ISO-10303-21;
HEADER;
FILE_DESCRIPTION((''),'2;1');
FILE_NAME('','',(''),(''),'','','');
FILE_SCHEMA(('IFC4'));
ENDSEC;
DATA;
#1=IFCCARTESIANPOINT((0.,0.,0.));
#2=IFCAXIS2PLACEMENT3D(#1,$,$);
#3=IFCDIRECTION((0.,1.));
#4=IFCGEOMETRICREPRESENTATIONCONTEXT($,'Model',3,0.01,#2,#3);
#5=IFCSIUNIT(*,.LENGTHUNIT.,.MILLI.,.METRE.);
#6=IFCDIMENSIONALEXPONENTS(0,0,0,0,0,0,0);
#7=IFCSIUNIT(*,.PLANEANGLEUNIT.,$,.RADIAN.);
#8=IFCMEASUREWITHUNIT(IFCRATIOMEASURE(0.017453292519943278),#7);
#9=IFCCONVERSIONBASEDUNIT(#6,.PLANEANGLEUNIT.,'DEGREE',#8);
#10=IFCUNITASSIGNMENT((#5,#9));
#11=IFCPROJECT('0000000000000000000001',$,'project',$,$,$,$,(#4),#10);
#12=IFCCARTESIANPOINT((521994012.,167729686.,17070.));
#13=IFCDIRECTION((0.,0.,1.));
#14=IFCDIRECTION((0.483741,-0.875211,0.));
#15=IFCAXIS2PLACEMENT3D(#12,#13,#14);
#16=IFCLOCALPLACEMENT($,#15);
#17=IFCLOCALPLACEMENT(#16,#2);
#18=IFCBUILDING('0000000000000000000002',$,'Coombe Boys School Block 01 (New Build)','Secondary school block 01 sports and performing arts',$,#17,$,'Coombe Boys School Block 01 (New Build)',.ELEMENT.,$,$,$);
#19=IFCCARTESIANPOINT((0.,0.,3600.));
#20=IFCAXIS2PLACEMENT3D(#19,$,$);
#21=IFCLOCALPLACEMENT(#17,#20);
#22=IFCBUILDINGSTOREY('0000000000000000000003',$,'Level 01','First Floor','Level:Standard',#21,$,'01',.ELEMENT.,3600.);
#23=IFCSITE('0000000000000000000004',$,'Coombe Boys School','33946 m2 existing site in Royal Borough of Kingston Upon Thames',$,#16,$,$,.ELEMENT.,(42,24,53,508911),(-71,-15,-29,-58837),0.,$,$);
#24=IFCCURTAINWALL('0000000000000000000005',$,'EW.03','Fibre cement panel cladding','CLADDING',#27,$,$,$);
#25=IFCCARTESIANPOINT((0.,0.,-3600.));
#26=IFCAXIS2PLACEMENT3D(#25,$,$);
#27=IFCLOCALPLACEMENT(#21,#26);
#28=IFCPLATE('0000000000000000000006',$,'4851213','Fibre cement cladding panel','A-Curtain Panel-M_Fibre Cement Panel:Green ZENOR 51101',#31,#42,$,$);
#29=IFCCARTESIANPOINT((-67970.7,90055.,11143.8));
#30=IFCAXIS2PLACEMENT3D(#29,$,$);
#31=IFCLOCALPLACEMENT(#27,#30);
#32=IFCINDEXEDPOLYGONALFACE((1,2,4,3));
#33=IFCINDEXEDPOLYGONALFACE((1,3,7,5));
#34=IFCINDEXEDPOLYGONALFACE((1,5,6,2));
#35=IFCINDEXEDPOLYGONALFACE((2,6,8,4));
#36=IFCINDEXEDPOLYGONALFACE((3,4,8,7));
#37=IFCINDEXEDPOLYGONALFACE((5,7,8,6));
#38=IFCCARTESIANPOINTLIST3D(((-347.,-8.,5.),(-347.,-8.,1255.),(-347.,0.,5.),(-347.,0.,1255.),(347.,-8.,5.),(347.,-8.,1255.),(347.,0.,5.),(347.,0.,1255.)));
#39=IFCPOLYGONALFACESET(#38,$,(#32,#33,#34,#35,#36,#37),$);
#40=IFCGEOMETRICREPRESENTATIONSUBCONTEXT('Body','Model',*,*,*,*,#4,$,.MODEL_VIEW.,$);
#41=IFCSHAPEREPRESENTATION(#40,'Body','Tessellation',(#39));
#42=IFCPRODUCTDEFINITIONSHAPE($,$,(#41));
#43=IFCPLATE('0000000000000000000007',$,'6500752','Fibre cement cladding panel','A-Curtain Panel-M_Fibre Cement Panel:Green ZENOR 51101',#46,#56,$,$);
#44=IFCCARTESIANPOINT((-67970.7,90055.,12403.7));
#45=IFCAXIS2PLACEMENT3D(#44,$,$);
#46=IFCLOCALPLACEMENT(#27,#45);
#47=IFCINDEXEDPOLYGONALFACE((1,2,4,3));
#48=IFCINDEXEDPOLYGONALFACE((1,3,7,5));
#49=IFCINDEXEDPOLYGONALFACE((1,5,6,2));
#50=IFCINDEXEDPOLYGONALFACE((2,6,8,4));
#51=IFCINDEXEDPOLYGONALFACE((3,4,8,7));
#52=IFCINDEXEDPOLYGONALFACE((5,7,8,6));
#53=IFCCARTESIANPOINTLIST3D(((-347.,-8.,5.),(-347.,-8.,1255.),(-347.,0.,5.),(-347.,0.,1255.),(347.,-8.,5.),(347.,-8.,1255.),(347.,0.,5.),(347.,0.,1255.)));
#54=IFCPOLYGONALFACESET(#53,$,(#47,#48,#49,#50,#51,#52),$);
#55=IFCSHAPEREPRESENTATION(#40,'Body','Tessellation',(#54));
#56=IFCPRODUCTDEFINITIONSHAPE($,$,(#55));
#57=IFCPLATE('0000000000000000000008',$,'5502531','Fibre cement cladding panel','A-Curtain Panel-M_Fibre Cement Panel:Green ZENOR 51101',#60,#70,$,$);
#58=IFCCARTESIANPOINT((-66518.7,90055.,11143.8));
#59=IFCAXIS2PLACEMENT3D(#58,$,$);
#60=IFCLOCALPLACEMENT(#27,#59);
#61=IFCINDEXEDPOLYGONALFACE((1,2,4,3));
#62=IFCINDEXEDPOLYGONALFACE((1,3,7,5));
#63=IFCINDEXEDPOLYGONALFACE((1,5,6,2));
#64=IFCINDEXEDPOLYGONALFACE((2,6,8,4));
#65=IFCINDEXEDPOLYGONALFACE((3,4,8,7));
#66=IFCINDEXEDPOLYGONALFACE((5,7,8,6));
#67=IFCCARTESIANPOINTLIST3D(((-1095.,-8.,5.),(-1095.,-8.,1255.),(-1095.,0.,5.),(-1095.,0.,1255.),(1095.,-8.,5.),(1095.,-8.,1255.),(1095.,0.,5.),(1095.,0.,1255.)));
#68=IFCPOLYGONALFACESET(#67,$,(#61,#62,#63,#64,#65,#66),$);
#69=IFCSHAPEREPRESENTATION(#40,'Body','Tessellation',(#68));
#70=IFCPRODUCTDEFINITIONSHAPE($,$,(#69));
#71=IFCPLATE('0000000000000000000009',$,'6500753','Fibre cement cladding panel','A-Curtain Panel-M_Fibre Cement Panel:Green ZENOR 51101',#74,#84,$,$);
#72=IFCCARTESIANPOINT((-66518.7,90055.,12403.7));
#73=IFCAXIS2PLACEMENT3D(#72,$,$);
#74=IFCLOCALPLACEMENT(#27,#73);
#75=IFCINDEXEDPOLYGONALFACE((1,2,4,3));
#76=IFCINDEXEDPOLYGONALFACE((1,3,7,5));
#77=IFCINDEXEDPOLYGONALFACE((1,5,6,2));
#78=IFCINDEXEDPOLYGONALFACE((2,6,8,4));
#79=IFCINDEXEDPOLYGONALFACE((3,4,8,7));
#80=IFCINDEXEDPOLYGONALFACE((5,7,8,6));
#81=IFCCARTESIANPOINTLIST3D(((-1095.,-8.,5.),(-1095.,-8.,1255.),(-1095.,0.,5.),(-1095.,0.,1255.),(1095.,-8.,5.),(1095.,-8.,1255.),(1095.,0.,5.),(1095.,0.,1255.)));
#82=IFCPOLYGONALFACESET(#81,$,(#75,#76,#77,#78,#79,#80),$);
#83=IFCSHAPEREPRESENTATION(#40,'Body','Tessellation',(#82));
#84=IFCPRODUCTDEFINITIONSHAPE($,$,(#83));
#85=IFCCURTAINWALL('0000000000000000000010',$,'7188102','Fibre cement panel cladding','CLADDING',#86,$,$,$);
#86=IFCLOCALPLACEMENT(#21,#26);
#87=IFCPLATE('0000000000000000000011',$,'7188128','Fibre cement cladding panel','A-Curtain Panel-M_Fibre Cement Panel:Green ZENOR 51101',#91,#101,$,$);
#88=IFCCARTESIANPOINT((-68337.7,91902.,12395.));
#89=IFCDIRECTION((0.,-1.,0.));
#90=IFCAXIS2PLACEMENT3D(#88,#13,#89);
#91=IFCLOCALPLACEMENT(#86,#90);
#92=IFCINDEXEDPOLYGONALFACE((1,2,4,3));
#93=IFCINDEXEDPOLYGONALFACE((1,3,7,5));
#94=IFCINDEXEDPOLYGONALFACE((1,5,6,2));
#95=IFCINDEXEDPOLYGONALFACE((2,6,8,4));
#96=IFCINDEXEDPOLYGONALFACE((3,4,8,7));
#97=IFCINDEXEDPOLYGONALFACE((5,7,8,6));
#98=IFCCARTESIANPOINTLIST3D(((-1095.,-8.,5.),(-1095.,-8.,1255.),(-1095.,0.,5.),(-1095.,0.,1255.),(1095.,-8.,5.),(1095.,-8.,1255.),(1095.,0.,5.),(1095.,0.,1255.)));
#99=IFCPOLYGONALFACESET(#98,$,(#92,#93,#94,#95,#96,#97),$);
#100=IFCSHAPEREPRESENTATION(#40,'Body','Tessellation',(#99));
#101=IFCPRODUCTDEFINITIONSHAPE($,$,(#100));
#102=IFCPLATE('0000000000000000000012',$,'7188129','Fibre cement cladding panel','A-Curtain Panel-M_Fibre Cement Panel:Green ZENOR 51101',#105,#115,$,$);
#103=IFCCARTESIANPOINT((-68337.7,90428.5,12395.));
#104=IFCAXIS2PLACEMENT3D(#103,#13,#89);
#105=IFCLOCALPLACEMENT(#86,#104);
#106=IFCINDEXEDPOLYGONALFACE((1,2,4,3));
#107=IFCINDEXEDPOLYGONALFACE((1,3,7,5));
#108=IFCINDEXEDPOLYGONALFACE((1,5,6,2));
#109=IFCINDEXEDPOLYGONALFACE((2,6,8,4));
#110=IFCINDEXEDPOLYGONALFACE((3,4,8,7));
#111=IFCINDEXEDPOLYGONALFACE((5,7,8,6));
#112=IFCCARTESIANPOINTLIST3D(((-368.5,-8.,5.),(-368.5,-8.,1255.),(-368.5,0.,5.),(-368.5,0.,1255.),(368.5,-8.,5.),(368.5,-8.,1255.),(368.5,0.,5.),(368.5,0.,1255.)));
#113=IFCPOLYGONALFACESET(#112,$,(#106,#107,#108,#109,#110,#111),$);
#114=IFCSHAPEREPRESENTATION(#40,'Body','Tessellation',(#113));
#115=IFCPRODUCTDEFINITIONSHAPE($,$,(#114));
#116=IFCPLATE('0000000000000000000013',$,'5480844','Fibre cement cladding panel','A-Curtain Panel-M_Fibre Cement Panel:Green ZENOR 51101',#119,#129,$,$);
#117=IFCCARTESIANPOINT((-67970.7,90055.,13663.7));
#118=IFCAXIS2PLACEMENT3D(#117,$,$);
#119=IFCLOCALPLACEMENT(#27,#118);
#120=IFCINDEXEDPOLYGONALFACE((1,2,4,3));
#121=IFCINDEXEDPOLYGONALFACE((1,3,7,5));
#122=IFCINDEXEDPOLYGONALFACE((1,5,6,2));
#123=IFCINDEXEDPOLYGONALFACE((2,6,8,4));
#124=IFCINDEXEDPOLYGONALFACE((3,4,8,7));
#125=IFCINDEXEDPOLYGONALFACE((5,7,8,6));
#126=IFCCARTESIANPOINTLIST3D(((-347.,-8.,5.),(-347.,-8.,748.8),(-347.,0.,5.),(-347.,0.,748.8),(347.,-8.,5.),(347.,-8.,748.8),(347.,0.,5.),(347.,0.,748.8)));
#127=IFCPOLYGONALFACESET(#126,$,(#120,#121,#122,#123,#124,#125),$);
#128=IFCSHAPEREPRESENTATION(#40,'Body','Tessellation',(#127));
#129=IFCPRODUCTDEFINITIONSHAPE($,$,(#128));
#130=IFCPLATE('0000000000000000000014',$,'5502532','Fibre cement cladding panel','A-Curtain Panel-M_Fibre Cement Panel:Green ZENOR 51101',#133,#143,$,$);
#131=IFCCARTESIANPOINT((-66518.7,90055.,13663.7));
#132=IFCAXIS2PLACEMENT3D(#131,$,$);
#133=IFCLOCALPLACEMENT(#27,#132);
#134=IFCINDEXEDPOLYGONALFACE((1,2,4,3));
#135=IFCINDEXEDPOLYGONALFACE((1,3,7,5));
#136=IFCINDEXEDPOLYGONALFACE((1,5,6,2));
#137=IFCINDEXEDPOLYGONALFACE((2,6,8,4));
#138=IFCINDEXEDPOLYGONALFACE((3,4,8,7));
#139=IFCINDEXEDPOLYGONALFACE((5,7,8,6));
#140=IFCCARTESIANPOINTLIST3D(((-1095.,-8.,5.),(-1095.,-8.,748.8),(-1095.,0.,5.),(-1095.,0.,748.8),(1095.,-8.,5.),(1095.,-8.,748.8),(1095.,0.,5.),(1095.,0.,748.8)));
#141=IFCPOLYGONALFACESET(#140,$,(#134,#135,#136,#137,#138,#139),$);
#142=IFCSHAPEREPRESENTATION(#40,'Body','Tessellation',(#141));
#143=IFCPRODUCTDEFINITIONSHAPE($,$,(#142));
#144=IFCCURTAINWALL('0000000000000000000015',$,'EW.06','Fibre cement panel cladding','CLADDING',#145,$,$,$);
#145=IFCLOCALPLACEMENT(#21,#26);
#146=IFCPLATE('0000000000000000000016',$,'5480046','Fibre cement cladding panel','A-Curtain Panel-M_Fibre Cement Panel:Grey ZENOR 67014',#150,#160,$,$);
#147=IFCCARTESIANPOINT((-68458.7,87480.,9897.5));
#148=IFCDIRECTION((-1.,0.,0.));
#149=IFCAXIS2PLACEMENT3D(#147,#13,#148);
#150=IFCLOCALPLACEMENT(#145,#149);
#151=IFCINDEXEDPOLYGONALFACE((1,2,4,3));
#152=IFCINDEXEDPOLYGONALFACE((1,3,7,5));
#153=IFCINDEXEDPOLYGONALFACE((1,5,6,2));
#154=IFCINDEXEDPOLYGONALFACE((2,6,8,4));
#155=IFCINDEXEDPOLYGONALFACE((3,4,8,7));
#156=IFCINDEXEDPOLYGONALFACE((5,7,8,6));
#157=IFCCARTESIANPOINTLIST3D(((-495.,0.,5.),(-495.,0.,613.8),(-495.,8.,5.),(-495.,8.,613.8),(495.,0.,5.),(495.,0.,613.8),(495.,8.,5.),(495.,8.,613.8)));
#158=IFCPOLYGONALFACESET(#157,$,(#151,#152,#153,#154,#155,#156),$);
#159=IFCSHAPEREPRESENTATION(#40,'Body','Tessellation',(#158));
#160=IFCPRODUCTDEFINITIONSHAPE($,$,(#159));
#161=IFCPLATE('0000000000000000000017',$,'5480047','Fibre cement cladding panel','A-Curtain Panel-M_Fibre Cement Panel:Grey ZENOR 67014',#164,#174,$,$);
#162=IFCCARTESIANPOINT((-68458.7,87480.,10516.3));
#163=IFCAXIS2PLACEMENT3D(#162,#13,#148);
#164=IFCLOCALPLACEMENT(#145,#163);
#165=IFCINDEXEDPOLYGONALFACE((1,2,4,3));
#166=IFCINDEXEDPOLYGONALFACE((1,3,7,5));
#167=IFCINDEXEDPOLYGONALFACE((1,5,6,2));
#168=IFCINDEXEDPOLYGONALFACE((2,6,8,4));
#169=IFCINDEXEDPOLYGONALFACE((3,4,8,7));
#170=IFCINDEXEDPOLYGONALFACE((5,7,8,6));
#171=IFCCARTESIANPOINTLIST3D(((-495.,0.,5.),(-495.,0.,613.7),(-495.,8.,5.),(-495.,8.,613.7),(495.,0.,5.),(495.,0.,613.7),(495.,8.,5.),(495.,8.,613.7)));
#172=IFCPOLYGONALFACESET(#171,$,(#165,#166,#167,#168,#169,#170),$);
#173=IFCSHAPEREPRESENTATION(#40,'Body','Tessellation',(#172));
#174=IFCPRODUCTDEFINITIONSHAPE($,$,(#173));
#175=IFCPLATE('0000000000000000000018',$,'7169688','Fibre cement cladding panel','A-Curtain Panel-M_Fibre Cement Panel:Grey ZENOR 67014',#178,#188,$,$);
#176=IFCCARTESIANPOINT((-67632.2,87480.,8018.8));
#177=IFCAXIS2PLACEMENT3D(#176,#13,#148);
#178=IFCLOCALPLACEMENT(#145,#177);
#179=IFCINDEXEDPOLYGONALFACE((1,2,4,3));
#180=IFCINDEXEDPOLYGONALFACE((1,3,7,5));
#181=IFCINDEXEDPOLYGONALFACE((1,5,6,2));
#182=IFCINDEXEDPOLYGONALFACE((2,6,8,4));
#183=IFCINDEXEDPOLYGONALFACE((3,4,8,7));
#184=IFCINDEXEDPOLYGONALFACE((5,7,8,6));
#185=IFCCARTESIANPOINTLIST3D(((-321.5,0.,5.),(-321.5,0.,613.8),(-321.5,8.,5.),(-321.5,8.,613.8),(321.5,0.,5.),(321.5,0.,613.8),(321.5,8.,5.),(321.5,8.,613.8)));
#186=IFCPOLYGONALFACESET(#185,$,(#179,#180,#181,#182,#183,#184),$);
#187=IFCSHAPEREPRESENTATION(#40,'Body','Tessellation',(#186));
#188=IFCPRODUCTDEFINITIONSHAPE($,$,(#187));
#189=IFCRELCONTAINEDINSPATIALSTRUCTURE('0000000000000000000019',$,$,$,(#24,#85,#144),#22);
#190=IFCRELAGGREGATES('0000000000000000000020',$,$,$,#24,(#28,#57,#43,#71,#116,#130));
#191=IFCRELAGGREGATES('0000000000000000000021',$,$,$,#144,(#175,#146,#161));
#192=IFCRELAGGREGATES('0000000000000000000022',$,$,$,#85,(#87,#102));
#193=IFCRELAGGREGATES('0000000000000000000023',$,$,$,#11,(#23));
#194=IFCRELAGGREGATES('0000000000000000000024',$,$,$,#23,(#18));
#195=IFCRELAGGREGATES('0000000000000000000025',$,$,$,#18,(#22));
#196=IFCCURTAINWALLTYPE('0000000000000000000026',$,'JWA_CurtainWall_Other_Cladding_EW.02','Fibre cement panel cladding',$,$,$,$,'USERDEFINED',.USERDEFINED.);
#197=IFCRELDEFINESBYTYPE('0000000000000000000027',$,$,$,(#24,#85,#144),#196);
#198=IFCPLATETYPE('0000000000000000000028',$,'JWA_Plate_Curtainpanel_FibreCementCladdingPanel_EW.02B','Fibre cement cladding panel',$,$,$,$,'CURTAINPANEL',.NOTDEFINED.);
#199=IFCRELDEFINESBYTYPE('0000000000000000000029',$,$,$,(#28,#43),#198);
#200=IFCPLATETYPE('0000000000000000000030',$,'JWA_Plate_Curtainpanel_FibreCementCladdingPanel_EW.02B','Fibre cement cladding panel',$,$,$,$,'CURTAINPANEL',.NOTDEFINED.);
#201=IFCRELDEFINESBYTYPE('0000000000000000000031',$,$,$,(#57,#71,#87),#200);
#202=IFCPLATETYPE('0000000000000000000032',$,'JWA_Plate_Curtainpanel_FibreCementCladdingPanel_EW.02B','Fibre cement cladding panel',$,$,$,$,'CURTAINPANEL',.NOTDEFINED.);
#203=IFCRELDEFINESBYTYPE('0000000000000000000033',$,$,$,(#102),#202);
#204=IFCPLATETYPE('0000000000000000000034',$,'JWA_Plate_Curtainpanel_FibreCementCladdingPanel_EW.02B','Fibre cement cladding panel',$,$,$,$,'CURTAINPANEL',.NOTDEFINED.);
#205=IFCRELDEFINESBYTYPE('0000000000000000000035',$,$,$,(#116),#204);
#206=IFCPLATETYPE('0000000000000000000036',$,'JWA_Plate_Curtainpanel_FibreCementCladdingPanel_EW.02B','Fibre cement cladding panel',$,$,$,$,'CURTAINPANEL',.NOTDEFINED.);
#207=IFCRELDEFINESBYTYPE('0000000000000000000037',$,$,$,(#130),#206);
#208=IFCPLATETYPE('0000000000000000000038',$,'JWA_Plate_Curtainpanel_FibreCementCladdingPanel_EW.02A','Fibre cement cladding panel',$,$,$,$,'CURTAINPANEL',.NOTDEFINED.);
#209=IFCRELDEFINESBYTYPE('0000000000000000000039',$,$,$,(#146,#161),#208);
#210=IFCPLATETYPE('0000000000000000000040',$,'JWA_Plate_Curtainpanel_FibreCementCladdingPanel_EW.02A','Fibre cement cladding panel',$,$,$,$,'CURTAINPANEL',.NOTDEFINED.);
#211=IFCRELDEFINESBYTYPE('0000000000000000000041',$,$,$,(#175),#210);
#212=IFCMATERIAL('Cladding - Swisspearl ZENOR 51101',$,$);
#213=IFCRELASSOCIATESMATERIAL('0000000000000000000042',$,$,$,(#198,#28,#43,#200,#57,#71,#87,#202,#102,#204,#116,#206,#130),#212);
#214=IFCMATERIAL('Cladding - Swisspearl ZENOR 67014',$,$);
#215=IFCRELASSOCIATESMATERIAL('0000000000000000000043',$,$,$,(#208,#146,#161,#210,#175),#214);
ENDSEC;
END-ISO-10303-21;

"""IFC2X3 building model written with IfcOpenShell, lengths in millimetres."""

from ifc_helpers import new_model, entity, si_unit, converted_unit, direction, frame, origin, origin_2d_with_axis, place, context, subcontext, project, spatial, rectangle, extrude, source, transform, mapped, material, type_object, type_shapes, element, aggregate, save


model = new_model("IFC2X3")

# Units and contexts
model_context = context("Model", 3, precision=0.01, world=origin(), true_north=direction((0.0, 1.0)))
body_context = subcontext(model_context, "Body", "Model", "MODEL_VIEW")
ifc_project = project(units=[si_unit("LENGTHUNIT", "METRE", prefix="MILLI"), converted_unit("PLANEANGLEUNIT", "DEGREE", entity("IfcRatioMeasure", 0.017453292519943278), si_unit("PLANEANGLEUNIT", "RADIAN"), dimensions=[0, 0, 0, 0, 0, 0, 0])], contexts=[model_context])

# Site, building, storey
site_placement = place(None, frame((521994012.0, 167729686.0, 17070.0), z_axis=(0.0, 0.0, 1.0), x_axis=(0.483741, -0.875211, 0.0)))
site = spatial("IfcSite", under=ifc_project, at=site_placement, Name="Coombe Boys School", Description="33946 m2 existing site in Royal Borough of Kingston Upon Thames", CompositionType="ELEMENT", RefLatitude=(42, 24, 53, 508911), RefLongitude=(-71, -15, -29, -58837), RefElevation=0.0)
building_placement = place(site_placement, origin())
building = spatial("IfcBuilding", under=site, at=building_placement, Name="Coombe Boys School Block 01 (New Build)", Description="Secondary school block 01 sports and performing arts", LongName="Coombe Boys School Block 01 (New Build)", CompositionType="ELEMENT")
storey_placement = place(building_placement, frame((0.0, 0.0, 3600.0)))
storey = spatial("IfcBuildingStorey", under=building, at=storey_placement, Name="Level 01", Description="First Floor", ObjectType="Level:Standard", LongName="01", CompositionType="ELEMENT", Elevation=3600.0)

# Curtain walls, plates
curtain_wall_type = type_object("IfcCurtainWallType", Name="JWA_CurtainWall_Other_Cladding_EW.02", Description="Fibre cement panel cladding", ElementType="USERDEFINED", PredefinedType="USERDEFINED")
curtain_wall_1_placement = place(storey_placement, frame((0.0, 0.0, -3600.0)))
curtain_wall_1 = element("IfcCurtainWall", 1, at=curtain_wall_1_placement, inside=storey, type_object=curtain_wall_type, Name="EW.03", Description="Fibre cement panel cladding", ObjectType="CLADDING")
ifc_material_1 = material(Name="Cladding - Swisspearl ZENOR 51101")
plate_type_1 = type_object("IfcPlateType", Name="JWA_Plate_Curtainpanel_FibreCementCladdingPanel_EW.02B", Description="Fibre cement cladding panel", ElementType="CURTAINPANEL", PredefinedType="NOTDEFINED", material=ifc_material_1)
shared_shape_1 = source(origin(), body_context, "Body", "SweptSolid", [
    extrude(rectangle(XDim=694.0, YDim=8.0, at=origin_2d_with_axis()), frame((0.0, -4.0, 5.0), z_axis=(0.0, 0.0, 1.0), x_axis=(-1.0, 0.0, 0.0)), (0.0, 0.0, 1.0), 1250.0),
])
type_shapes(plate_type_1, [shared_shape_1])
plate_1_placement = place(curtain_wall_1_placement, frame((-67970.7, 90055.0, 11143.8)))
plate_1 = element("IfcPlate", 2, at=plate_1_placement, type_object=plate_type_1, material=ifc_material_1, Name="4851213", Description="Fibre cement cladding panel", ObjectType="A-Curtain Panel-M_Fibre Cement Panel:Green ZENOR 51101", context=body_context, shape_type="MappedRepresentation", body=[
    mapped(shared_shape_1, transform((0.0, 0.0, 0.0), scale=1.0)),
])
plate_2_placement = place(curtain_wall_1_placement, frame((-67970.7, 90055.0, 12403.7)))
plate_2 = element("IfcPlate", 3, at=plate_2_placement, type_object=plate_type_1, material=ifc_material_1, Name="6500752", Description="Fibre cement cladding panel", ObjectType="A-Curtain Panel-M_Fibre Cement Panel:Green ZENOR 51101", context=body_context, shape_type="MappedRepresentation", body=[
    mapped(shared_shape_1, transform((0.0, 0.0, 0.0), scale=1.0)),
])
plate_type_2 = type_object("IfcPlateType", Name="JWA_Plate_Curtainpanel_FibreCementCladdingPanel_EW.02B", Description="Fibre cement cladding panel", ElementType="CURTAINPANEL", PredefinedType="NOTDEFINED", material=ifc_material_1)
shared_shape_2 = source(origin(), body_context, "Body", "SweptSolid", [
    extrude(rectangle(XDim=2190.0, YDim=8.0, at=origin_2d_with_axis()), frame((0.0, -4.0, 5.0), z_axis=(0.0, 0.0, 1.0), x_axis=(-1.0, 0.0, 0.0)), (0.0, 0.0, 1.0), 1250.0),
])
type_shapes(plate_type_2, [shared_shape_2])
plate_3_placement = place(curtain_wall_1_placement, frame((-66518.7, 90055.0, 11143.8)))
plate_3 = element("IfcPlate", 4, at=plate_3_placement, type_object=plate_type_2, material=ifc_material_1, Name="5502531", Description="Fibre cement cladding panel", ObjectType="A-Curtain Panel-M_Fibre Cement Panel:Green ZENOR 51101", context=body_context, shape_type="MappedRepresentation", body=[
    mapped(shared_shape_2, transform((0.0, 0.0, 0.0), scale=1.0)),
])
plate_4_placement = place(curtain_wall_1_placement, frame((-66518.7, 90055.0, 12403.7)))
plate_4 = element("IfcPlate", 5, at=plate_4_placement, type_object=plate_type_2, material=ifc_material_1, Name="6500753", Description="Fibre cement cladding panel", ObjectType="A-Curtain Panel-M_Fibre Cement Panel:Green ZENOR 51101", context=body_context, shape_type="MappedRepresentation", body=[
    mapped(shared_shape_2, transform((0.0, 0.0, 0.0), scale=1.0)),
])
curtain_wall_2_placement = place(storey_placement, frame((0.0, 0.0, -3600.0)))
curtain_wall_2 = element("IfcCurtainWall", 6, at=curtain_wall_2_placement, inside=storey, type_object=curtain_wall_type, Name="7188102", Description="Fibre cement panel cladding", ObjectType="CLADDING")
plate_5_placement = place(curtain_wall_2_placement, frame((-68337.7, 91902.0, 12395.0), z_axis=(0.0, 0.0, 1.0), x_axis=(0.0, -1.0, 0.0)))
plate_5 = element("IfcPlate", 7, at=plate_5_placement, type_object=plate_type_2, material=ifc_material_1, Name="7188128", Description="Fibre cement cladding panel", ObjectType="A-Curtain Panel-M_Fibre Cement Panel:Green ZENOR 51101", context=body_context, shape_type="MappedRepresentation", body=[
    mapped(shared_shape_2, transform((0.0, 0.0, 0.0), scale=1.0)),
])
plate_type_3 = type_object("IfcPlateType", Name="JWA_Plate_Curtainpanel_FibreCementCladdingPanel_EW.02B", Description="Fibre cement cladding panel", ElementType="CURTAINPANEL", PredefinedType="NOTDEFINED", material=ifc_material_1)
shared_shape_3 = source(origin(), body_context, "Body", "SweptSolid", [
    extrude(rectangle(XDim=737.0, YDim=8.0, at=origin_2d_with_axis()), frame((0.0, -4.0, 5.0), z_axis=(0.0, 0.0, 1.0), x_axis=(-1.0, 0.0, 0.0)), (0.0, 0.0, 1.0), 1250.0),
])
type_shapes(plate_type_3, [shared_shape_3])
plate_6_placement = place(curtain_wall_2_placement, frame((-68337.7, 90428.5, 12395.0), z_axis=(0.0, 0.0, 1.0), x_axis=(0.0, -1.0, 0.0)))
plate_6 = element("IfcPlate", 8, at=plate_6_placement, type_object=plate_type_3, material=ifc_material_1, Name="7188129", Description="Fibre cement cladding panel", ObjectType="A-Curtain Panel-M_Fibre Cement Panel:Green ZENOR 51101", context=body_context, shape_type="MappedRepresentation", body=[
    mapped(shared_shape_3, transform((0.0, 0.0, 0.0), scale=1.0)),
])

# Plates
plate_type_4 = type_object("IfcPlateType", Name="JWA_Plate_Curtainpanel_FibreCementCladdingPanel_EW.02B", Description="Fibre cement cladding panel", ElementType="CURTAINPANEL", PredefinedType="NOTDEFINED", material=ifc_material_1)
shared_shape_4 = source(origin(), body_context, "Body", "SweptSolid", [
    extrude(rectangle(XDim=694.0, YDim=8.0, at=origin_2d_with_axis()), frame((0.0, -4.0, 5.0), z_axis=(0.0, 0.0, 1.0), x_axis=(-1.0, 0.0, 0.0)), (0.0, 0.0, 1.0), 743.8),
])
type_shapes(plate_type_4, [shared_shape_4])
plate_7_placement = place(curtain_wall_1_placement, frame((-67970.7, 90055.0, 13663.7)))
plate_7 = element("IfcPlate", 9, at=plate_7_placement, type_object=plate_type_4, material=ifc_material_1, Name="5480844", Description="Fibre cement cladding panel", ObjectType="A-Curtain Panel-M_Fibre Cement Panel:Green ZENOR 51101", context=body_context, shape_type="MappedRepresentation", body=[
    mapped(shared_shape_4, transform((0.0, 0.0, 0.0), scale=1.0)),
])
plate_type_5 = type_object("IfcPlateType", Name="JWA_Plate_Curtainpanel_FibreCementCladdingPanel_EW.02B", Description="Fibre cement cladding panel", ElementType="CURTAINPANEL", PredefinedType="NOTDEFINED", material=ifc_material_1)
shared_shape_5 = source(origin(), body_context, "Body", "SweptSolid", [
    extrude(rectangle(XDim=2190.0, YDim=8.0, at=origin_2d_with_axis()), frame((0.0, -4.0, 5.0), z_axis=(0.0, 0.0, 1.0), x_axis=(-1.0, 0.0, 0.0)), (0.0, 0.0, 1.0), 743.8),
])
type_shapes(plate_type_5, [shared_shape_5])
plate_8_placement = place(curtain_wall_1_placement, frame((-66518.7, 90055.0, 13663.7)))
plate_8 = element("IfcPlate", 10, at=plate_8_placement, type_object=plate_type_5, material=ifc_material_1, Name="5502532", Description="Fibre cement cladding panel", ObjectType="A-Curtain Panel-M_Fibre Cement Panel:Green ZENOR 51101", context=body_context, shape_type="MappedRepresentation", body=[
    mapped(shared_shape_5, transform((0.0, 0.0, 0.0), scale=1.0)),
])
aggregate(curtain_wall_1, [plate_1, plate_3, plate_2, plate_4, plate_7, plate_8])

# Curtain wall, plates
curtain_wall_3_placement = place(storey_placement, frame((0.0, 0.0, -3600.0)))
curtain_wall_3 = element("IfcCurtainWall", 11, at=curtain_wall_3_placement, inside=storey, type_object=curtain_wall_type, Name="EW.06", Description="Fibre cement panel cladding", ObjectType="CLADDING")
ifc_material_2 = material(Name="Cladding - Swisspearl ZENOR 67014")
plate_type_6 = type_object("IfcPlateType", Name="JWA_Plate_Curtainpanel_FibreCementCladdingPanel_EW.02A", Description="Fibre cement cladding panel", ElementType="CURTAINPANEL", PredefinedType="NOTDEFINED", material=ifc_material_2)
shared_shape_6 = source(origin(), body_context, "Body", "SweptSolid", [
    extrude(rectangle(XDim=8.0, YDim=990.0, at=origin_2d_with_axis()), frame((0.0, 4.0, 5.0), z_axis=(0.0, 0.0, 1.0), x_axis=(0.0, 1.0, 0.0)), (0.0, 0.0, 1.0), 608.8),
])
type_shapes(plate_type_6, [shared_shape_6])
plate_9_placement = place(curtain_wall_3_placement, frame((-68458.7, 87480.0, 9897.5), z_axis=(0.0, 0.0, 1.0), x_axis=(-1.0, 0.0, 0.0)))
plate_9 = element("IfcPlate", 12, at=plate_9_placement, type_object=plate_type_6, material=ifc_material_2, Name="5480046", Description="Fibre cement cladding panel", ObjectType="A-Curtain Panel-M_Fibre Cement Panel:Grey ZENOR 67014", context=body_context, shape_type="MappedRepresentation", body=[
    mapped(shared_shape_6, transform((0.0, 0.0, 0.0), scale=1.0)),
])
plate_10_placement = place(curtain_wall_3_placement, frame((-68458.7, 87480.0, 10516.3), z_axis=(0.0, 0.0, 1.0), x_axis=(-1.0, 0.0, 0.0)))
plate_10 = element("IfcPlate", 13, at=plate_10_placement, type_object=plate_type_6, material=ifc_material_2, Name="5480047", Description="Fibre cement cladding panel", ObjectType="A-Curtain Panel-M_Fibre Cement Panel:Grey ZENOR 67014", context=body_context, shape_type="MappedRepresentation", body=[
    mapped(shared_shape_6, transform((0.0, 0.0, 0.0), scale=1.0)),
])
plate_type_7 = type_object("IfcPlateType", Name="JWA_Plate_Curtainpanel_FibreCementCladdingPanel_EW.02A", Description="Fibre cement cladding panel", ElementType="CURTAINPANEL", PredefinedType="NOTDEFINED", material=ifc_material_2)
shared_shape_7 = source(origin(), body_context, "Body", "SweptSolid", [
    extrude(rectangle(XDim=8.0, YDim=643.0, at=origin_2d_with_axis()), frame((0.0, 4.0, 5.0), z_axis=(0.0, 0.0, 1.0), x_axis=(0.0, 1.0, 0.0)), (0.0, 0.0, 1.0), 608.8),
])
type_shapes(plate_type_7, [shared_shape_7])
plate_11_placement = place(curtain_wall_3_placement, frame((-67632.2, 87480.0, 8018.8), z_axis=(0.0, 0.0, 1.0), x_axis=(-1.0, 0.0, 0.0)))
plate_11 = element("IfcPlate", 14, at=plate_11_placement, type_object=plate_type_7, material=ifc_material_2, Name="7169688", Description="Fibre cement cladding panel", ObjectType="A-Curtain Panel-M_Fibre Cement Panel:Grey ZENOR 67014", context=body_context, shape_type="MappedRepresentation", body=[
    mapped(shared_shape_7, transform((0.0, 0.0, 0.0), scale=1.0)),
])
aggregate(curtain_wall_3, [plate_11, plate_9, plate_10])

aggregate(curtain_wall_2, [plate_5, plate_6])

save(model, "model.ifc")
